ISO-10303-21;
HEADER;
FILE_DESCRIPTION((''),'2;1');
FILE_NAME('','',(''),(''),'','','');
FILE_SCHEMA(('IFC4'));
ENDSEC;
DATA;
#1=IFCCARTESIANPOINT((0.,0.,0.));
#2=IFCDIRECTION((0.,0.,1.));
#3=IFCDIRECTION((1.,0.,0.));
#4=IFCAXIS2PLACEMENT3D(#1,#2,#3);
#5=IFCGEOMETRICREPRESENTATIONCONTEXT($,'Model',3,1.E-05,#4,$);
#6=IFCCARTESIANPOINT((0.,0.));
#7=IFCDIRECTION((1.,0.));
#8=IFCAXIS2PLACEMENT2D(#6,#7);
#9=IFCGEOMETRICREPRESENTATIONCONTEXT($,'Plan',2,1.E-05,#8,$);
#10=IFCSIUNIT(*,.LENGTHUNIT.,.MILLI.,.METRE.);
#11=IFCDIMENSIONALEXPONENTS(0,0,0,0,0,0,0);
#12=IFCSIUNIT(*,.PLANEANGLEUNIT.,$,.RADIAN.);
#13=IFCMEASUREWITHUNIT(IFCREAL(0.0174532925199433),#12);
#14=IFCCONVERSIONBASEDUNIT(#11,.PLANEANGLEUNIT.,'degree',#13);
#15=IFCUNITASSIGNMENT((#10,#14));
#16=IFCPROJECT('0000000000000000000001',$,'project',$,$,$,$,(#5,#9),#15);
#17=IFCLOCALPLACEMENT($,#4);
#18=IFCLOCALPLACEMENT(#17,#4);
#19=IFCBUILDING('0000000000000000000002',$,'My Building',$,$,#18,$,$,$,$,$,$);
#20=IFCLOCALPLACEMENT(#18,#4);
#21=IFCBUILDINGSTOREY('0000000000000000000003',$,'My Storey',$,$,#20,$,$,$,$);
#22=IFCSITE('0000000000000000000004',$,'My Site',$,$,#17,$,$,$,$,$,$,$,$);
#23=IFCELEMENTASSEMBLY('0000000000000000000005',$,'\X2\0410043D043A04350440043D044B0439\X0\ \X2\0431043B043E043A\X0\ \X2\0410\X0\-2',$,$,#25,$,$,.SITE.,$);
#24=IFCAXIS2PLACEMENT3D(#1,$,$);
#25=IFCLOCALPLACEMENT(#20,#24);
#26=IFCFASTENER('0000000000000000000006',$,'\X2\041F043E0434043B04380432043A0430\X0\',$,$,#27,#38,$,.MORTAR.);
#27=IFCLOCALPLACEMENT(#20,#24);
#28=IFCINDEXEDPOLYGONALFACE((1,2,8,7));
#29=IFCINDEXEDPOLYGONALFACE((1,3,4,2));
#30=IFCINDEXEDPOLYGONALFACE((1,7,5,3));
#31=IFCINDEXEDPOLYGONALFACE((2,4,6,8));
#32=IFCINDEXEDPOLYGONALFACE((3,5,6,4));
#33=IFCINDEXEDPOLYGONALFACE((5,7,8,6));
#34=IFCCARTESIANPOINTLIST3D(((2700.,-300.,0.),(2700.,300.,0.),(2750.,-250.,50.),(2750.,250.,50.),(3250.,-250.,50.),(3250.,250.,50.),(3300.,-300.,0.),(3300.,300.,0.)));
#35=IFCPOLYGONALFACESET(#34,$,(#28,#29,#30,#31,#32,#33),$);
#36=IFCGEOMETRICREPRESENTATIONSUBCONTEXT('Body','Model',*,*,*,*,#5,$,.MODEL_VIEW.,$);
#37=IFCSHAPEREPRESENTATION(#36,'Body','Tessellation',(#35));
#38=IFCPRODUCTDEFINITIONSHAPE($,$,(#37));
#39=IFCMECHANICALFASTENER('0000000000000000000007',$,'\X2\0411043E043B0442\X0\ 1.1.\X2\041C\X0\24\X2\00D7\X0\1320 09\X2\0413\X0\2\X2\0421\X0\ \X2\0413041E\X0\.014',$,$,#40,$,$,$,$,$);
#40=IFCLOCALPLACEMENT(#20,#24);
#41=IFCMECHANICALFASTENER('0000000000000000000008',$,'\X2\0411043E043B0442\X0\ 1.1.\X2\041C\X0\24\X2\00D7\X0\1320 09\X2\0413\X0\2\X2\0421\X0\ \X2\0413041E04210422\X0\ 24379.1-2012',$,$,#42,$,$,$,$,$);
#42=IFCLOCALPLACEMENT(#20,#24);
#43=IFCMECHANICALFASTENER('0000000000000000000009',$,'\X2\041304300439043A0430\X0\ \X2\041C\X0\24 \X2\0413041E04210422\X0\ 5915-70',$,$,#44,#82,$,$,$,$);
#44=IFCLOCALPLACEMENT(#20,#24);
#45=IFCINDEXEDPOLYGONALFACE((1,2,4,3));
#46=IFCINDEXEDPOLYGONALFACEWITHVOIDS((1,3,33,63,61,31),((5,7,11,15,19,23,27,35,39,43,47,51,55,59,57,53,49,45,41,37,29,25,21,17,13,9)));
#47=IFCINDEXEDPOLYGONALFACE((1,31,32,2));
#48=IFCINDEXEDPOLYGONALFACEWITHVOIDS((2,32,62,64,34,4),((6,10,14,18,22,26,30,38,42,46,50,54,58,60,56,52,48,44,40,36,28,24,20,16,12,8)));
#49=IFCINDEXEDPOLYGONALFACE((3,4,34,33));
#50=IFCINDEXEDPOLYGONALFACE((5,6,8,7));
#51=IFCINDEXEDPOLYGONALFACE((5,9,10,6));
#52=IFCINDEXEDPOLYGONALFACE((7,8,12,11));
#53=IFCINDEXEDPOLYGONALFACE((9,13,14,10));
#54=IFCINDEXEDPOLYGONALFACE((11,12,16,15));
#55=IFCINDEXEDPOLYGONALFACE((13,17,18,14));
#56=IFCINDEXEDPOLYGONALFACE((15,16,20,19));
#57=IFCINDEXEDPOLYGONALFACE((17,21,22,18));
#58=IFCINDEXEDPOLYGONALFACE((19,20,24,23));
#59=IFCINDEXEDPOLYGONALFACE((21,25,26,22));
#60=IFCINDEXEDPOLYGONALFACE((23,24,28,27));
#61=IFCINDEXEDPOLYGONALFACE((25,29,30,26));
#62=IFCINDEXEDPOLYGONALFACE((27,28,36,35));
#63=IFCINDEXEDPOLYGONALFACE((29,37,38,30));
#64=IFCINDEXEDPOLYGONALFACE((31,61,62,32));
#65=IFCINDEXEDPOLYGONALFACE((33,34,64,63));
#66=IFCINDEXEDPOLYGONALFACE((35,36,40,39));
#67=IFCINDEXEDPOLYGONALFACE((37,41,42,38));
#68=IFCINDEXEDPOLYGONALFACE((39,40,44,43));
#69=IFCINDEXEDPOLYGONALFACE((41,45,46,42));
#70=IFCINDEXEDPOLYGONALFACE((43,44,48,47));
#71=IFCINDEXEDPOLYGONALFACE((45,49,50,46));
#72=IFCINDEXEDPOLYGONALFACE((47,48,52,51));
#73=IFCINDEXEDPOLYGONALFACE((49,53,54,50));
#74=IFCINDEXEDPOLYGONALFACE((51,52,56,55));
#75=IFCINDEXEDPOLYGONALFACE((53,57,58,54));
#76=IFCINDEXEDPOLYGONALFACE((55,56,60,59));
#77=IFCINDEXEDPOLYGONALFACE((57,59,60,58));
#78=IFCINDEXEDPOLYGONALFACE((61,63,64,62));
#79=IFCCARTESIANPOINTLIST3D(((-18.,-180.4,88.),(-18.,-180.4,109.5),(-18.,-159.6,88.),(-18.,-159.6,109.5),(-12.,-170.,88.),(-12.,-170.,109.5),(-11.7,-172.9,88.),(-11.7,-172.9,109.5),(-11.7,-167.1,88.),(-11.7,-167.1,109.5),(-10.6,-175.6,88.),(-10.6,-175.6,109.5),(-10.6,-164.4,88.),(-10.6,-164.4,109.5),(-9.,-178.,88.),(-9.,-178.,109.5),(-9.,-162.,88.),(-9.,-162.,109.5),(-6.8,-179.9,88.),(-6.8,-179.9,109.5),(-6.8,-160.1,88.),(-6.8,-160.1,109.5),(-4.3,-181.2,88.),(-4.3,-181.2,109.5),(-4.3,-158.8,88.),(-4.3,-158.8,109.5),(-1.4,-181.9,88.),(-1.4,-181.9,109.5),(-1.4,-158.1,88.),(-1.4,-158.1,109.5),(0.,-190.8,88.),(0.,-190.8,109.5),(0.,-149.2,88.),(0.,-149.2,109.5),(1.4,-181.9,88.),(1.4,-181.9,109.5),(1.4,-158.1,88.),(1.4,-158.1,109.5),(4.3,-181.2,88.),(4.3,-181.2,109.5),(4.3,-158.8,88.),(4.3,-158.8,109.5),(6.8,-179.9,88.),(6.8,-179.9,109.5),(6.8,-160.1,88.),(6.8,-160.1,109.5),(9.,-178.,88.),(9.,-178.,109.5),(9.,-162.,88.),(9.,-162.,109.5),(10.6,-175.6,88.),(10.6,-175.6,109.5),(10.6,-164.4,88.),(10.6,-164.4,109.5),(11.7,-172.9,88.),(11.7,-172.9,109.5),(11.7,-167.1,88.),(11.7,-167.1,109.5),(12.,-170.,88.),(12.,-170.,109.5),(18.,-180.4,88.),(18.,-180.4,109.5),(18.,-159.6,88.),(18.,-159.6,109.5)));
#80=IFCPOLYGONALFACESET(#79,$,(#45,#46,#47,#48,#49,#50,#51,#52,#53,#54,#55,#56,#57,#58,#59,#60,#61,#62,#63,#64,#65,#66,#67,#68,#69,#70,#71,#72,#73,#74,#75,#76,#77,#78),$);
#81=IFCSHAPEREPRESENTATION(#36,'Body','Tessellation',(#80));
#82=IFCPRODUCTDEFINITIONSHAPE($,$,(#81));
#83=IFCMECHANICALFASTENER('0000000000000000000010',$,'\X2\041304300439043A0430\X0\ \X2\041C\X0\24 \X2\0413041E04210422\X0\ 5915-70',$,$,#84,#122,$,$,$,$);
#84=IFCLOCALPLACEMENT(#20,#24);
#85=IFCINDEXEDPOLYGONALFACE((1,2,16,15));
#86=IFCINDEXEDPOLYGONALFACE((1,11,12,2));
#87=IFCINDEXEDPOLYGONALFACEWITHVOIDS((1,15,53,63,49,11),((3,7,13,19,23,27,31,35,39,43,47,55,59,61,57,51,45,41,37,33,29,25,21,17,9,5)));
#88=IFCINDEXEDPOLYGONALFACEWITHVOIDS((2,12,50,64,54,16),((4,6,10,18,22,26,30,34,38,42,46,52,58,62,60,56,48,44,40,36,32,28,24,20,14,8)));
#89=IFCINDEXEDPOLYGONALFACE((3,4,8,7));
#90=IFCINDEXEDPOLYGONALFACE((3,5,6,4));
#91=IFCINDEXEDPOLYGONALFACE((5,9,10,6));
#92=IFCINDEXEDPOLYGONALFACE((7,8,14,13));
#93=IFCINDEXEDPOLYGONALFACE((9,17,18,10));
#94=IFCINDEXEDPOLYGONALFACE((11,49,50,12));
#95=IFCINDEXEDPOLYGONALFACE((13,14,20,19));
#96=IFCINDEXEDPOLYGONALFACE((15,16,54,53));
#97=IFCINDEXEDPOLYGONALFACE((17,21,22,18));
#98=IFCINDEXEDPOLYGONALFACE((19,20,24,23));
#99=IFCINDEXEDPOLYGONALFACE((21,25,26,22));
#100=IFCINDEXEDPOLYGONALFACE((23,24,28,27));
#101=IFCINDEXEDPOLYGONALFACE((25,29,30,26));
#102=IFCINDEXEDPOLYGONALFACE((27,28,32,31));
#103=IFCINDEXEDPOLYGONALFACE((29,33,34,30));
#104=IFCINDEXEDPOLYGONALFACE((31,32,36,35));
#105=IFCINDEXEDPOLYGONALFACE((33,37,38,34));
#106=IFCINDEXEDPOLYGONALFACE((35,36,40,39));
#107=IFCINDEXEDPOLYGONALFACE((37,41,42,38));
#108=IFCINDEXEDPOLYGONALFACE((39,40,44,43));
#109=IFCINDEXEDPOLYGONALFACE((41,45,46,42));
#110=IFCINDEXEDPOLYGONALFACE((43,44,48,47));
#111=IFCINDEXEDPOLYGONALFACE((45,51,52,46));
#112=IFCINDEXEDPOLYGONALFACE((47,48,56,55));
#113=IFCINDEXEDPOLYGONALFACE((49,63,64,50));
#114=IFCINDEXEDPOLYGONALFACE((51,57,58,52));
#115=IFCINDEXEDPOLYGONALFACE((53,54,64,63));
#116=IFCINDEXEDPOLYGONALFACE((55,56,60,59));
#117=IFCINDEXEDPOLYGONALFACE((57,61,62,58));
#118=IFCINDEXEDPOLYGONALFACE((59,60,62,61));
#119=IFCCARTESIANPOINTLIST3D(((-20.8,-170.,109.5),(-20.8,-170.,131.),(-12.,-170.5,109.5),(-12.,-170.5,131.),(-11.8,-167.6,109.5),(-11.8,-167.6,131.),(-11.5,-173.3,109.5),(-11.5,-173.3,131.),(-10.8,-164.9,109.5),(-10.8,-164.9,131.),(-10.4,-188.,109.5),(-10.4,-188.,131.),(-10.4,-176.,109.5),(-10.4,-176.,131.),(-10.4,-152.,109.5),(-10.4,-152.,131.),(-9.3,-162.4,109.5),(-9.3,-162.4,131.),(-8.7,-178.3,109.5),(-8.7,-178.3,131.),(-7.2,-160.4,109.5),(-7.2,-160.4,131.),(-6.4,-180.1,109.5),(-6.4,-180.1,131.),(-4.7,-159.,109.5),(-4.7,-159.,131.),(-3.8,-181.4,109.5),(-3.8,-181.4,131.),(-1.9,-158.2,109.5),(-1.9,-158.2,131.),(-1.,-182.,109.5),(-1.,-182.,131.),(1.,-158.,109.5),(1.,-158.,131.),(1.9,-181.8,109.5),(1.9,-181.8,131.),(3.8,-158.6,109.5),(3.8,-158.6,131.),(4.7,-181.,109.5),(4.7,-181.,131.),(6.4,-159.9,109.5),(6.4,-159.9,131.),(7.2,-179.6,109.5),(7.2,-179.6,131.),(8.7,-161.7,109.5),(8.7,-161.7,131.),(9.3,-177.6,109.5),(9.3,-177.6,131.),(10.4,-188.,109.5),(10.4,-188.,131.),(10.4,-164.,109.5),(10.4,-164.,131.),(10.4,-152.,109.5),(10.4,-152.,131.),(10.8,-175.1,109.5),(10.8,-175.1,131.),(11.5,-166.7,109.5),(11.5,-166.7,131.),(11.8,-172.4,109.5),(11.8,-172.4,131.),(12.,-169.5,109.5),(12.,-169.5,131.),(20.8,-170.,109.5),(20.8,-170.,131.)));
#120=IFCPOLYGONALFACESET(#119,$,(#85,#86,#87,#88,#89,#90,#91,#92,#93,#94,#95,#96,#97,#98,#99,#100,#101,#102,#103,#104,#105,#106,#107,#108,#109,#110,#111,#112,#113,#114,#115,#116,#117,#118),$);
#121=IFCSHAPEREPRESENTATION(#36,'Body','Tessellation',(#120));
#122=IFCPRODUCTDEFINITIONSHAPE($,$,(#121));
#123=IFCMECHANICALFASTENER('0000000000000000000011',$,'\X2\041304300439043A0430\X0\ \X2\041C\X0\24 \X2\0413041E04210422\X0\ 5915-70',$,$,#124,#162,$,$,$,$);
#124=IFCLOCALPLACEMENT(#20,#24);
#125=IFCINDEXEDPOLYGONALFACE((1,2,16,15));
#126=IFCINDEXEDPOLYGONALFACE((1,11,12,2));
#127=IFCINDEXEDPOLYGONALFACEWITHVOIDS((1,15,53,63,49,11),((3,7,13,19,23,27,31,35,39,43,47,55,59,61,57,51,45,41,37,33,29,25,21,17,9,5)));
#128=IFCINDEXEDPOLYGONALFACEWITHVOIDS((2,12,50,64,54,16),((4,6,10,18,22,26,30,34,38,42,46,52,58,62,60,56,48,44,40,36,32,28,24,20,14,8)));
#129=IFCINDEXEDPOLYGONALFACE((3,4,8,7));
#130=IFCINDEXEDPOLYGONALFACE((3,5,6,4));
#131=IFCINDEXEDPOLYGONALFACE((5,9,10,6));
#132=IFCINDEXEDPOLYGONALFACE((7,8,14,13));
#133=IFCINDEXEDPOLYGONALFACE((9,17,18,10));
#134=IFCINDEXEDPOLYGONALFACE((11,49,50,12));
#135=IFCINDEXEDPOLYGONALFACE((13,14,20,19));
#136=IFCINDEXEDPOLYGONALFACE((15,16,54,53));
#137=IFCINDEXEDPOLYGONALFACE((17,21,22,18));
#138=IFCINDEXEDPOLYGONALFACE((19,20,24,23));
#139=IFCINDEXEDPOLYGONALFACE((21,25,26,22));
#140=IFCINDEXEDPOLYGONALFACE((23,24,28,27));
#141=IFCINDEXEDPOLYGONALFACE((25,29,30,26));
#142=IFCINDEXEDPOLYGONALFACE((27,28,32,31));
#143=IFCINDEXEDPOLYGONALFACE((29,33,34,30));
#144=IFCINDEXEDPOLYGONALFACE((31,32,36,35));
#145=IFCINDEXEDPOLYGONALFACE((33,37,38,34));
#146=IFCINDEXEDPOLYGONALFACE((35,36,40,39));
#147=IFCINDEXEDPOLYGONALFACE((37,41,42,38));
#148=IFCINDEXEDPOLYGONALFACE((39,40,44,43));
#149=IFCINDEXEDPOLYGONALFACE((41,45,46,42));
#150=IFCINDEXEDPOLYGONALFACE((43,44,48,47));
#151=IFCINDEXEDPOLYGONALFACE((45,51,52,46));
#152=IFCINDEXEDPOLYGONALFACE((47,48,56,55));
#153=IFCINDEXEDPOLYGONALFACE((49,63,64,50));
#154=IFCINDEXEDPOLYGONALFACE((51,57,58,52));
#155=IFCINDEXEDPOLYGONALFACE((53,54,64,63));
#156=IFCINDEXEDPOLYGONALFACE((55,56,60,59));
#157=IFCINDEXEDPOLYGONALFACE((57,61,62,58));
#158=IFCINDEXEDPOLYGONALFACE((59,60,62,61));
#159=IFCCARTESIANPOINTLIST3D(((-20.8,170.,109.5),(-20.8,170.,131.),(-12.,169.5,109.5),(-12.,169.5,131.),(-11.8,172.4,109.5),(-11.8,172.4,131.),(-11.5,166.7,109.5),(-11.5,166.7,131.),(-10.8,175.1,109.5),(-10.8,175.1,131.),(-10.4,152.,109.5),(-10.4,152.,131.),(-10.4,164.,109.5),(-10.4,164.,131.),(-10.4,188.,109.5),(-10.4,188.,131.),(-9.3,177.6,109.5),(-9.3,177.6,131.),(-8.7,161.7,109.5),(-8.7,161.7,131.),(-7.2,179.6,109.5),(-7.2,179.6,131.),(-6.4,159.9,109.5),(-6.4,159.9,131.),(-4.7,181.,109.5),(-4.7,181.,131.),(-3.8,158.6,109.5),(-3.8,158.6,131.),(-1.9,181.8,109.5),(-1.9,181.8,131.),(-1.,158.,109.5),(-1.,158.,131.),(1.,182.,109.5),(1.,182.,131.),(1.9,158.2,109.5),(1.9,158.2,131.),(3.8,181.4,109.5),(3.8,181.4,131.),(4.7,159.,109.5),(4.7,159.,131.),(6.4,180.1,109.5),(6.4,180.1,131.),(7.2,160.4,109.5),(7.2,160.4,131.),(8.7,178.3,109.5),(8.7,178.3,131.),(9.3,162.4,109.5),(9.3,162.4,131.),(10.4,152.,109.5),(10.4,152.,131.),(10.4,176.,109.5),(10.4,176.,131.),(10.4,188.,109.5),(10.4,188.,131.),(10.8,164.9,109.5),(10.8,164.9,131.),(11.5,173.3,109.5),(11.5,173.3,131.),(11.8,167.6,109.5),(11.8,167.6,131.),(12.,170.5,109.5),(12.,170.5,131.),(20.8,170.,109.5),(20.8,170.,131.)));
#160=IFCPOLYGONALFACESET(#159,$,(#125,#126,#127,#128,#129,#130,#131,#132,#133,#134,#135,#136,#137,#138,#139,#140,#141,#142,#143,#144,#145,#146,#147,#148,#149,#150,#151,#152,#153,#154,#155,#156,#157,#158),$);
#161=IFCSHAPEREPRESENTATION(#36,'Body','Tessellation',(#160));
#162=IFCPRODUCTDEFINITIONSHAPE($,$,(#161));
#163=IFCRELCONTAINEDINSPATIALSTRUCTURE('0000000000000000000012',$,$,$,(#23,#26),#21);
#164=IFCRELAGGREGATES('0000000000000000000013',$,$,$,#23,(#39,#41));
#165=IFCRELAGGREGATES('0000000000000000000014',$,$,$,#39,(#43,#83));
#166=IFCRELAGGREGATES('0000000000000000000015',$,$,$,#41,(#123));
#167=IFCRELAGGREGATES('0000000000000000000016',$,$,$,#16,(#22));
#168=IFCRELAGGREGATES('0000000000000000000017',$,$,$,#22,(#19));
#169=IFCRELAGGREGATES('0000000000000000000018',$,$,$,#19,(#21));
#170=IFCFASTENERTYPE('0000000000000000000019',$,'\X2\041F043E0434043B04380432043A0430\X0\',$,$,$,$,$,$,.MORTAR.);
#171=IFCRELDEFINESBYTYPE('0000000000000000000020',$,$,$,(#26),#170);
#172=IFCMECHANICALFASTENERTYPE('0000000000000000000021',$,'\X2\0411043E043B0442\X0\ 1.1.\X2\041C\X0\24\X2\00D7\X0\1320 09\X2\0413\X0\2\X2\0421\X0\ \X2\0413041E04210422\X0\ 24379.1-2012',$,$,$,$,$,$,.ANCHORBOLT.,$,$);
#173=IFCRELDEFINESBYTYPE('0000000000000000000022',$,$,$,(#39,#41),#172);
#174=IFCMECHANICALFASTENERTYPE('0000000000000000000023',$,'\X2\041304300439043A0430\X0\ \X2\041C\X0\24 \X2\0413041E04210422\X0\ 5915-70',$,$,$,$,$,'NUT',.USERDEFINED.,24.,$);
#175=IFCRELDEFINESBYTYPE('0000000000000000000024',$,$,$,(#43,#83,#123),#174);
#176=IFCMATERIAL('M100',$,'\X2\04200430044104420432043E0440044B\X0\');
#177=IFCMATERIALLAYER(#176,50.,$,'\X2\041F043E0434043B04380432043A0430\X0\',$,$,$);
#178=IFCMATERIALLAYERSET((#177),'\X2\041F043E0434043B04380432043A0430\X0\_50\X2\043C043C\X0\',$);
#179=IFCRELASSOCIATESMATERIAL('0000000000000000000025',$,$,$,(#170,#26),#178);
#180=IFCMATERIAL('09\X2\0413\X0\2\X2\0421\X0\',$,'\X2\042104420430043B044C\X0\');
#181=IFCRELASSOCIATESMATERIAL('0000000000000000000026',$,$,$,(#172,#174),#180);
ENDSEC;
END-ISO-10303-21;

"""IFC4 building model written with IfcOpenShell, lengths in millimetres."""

from ifc_helpers import new_model, entity, si_unit, converted_unit, frame, origin_with_axes, origin_2d_with_axis, place, context, subcontext, project, spatial, polyline, line, indexed_curve, outline, extrude, clip, halfspace, source, transform, mapped, material, layer, layer_set, layer_usage, type_object, type_shapes, element, aggregate, save


model = new_model("IFC4")

# Units and contexts
model_context = context("Model", 3, precision=1e-05, world=origin_with_axes())
plan_context = context("Plan", 2, precision=1e-05, world=origin_2d_with_axis())
body_context = subcontext(model_context, "Body", "Model", "MODEL_VIEW")
ifc_project = project(units=[si_unit("LENGTHUNIT", "METRE", prefix="MILLI"), converted_unit("PLANEANGLEUNIT", "degree", entity("IfcReal", 0.0174532925199433), si_unit("PLANEANGLEUNIT", "RADIAN"), dimensions=[0, 0, 0, 0, 0, 0, 0])], contexts=[model_context, plan_context])

# Site, building, storey
site_placement = place(None, origin_with_axes())
site = spatial("IfcSite", under=ifc_project, at=site_placement, Name="My Site")
building_placement = place(site_placement, origin_with_axes())
building = spatial("IfcBuilding", under=site, at=building_placement, Name="My Building")
storey_placement = place(building_placement, origin_with_axes())
storey = spatial("IfcBuildingStorey", under=building, at=storey_placement, Name="My Storey")

# Element assembly
placement_1 = place(storey_placement, origin_with_axes())
assembly_1 = element("IfcElementAssembly", 1, at=placement_1, inside=storey, Name="Анкерный блок А-2", AssemblyPlace="SITE")
placement_2 = place(storey_placement, frame((3000.0, 0.0, 0.0), z_axis=(0.0, 0.0, 1.0), x_axis=(1.0, 0.0, 0.0)))

# Fastener
ifc_material_1 = material(Name="M100", Category="Растворы")
ifc_layer_1 = layer(ifc_material_1, 50.0, Name="Подливка")
ifc_layer_set_1 = layer_set([ifc_layer_1], Name="Подливка_50мм")
ifc_layer_usage_1 = layer_usage(ifc_layer_set_1, "AXIS3", "POSITIVE", 0.0)
fastener_type = type_object("IfcFastenerType", Name="Подливка", PredefinedType="MORTAR", material=ifc_layer_set_1)
element("IfcFastener", 2, at=placement_2, inside=storey, type_object=fastener_type, material=ifc_layer_usage_1, Name="Подливка", PredefinedType="MORTAR", context=body_context, shape_type="Clipping", body=[
    clip(clip(clip(clip(extrude(outline(indexed_curve([(-300.0, -300.0), (300.0, -300.0), (300.0, 300.0), (-300.0, 300.0)], segments=[line(3, 2), line(2, 1), line(1, 4), line(4, 3)], self_intersect=False)), None, (0.0, 0.0, 1.0), 50.0), halfspace(frame((-53.6, 200.0, 353.6), z_axis=(0.707107, 0.0, 0.707107), x_axis=(0.707107, 0.0, -0.707107)), False)), halfspace(frame((-200.0, -53.6, 353.6), z_axis=(0.0, 0.707107, 0.707107), x_axis=(0.0, 0.707107, -0.707107)), False)), halfspace(frame((200.0, 53.6, 353.6), z_axis=(0.0, -0.707107, 0.707107), x_axis=(0.0, -0.707107, -0.707107)), False)), halfspace(frame((53.6, 200.0, 353.6), z_axis=(-0.707107, 0.0, 0.707107), x_axis=(-0.707107, 0.0, -0.707107)), False)),
])

# Mechanical fastener
ifc_material_2 = material(Name="09Г2С", Category="Сталь")
mechanical_fastener_type_1 = type_object("IfcMechanicalFastenerType", Name="Болт 1.1.М24×1320 09Г2С ГОСТ 24379.1-2012", PredefinedType="ANCHORBOLT", material=ifc_material_2)
mechanical_fastener_1_placement = place(placement_1, frame((0.0, -170.0, 0.0), z_axis=(0.0, 0.0, 1.0), x_axis=(1.0, 0.0, 0.0)))
mechanical_fastener_1 = element("IfcMechanicalFastener", 3, at=mechanical_fastener_1_placement, type_object=mechanical_fastener_type_1, Name="Болт 1.1.М24×1320 09Г2С ГО.014")

# Mechanical fastener
mechanical_fastener_2_placement = place(placement_1, frame((0.0, 170.0, 0.0), z_axis=(0.0, 0.0, 1.0), x_axis=(-1.0, 0.0, 0.0)))
mechanical_fastener_2 = element("IfcMechanicalFastener", 4, at=mechanical_fastener_2_placement, type_object=mechanical_fastener_type_1, Name="Болт 1.1.М24×1320 09Г2С ГОСТ 24379.1-2012")
aggregate(assembly_1, [mechanical_fastener_1, mechanical_fastener_2])

# Mechanical fasteners
mechanical_fastener_type_2 = type_object("IfcMechanicalFastenerType", Name="Гайка М24 ГОСТ 5915-70", ElementType="NUT", NominalDiameter=24.0, PredefinedType="USERDEFINED", material=ifc_material_2)
shared_shape_1 = source(origin_with_axes(), body_context, "Body", "SweptSolid", [
    extrude(outline(polyline([(-10.4, -18.0), (10.4, -18.0), (20.8, 0.0), (10.4, 18.0), (-10.4, 18.0), (-20.8, 0.0), (-10.4, -18.0)]), holes=[polyline([(-8.0, 9.0), (-5.6, 10.6), (-2.9, 11.7), (0.0, 12.0), (2.9, 11.7), (5.6, 10.6), (8.0, 9.0), (9.9, 6.8), (11.2, 4.3), (11.9, 1.4), (11.9, -1.4), (11.2, -4.3), (9.9, -6.8), (8.0, -9.0), (5.6, -10.6), (2.9, -11.7), (0.0, -12.0), (-2.9, -11.7), (-5.6, -10.6), (-8.0, -9.0), (-9.9, -6.8), (-11.2, -4.3), (-11.9, -1.4), (-11.9, 1.4), (-11.2, 4.3), (-9.9, 6.8), (-8.0, 9.0)])]), frame((0.0, 0.0, 0.0), z_axis=(0.0, 0.0, 1.0), x_axis=(0.0, 1.0, 0.0)), (0.0, 0.0, 1.0), 21.5),
])
type_shapes(mechanical_fastener_type_2, [shared_shape_1])
mechanical_fastener_3_placement = place(mechanical_fastener_1_placement, frame((0.0, 0.0, 88.0), z_axis=(0.0, 0.0, 1.0), x_axis=(1.0, 0.0, 0.0)))
mechanical_fastener_3 = element("IfcMechanicalFastener", 5, at=mechanical_fastener_3_placement, type_object=mechanical_fastener_type_2, Name="Гайка М24 ГОСТ 5915-70", context=body_context, shape_type="MappedRepresentation", body=[
    mapped(shared_shape_1, transform((0.0, 0.0, 0.0), x_axis=(1.0, 0.0, 0.0), y_axis=(0.0, 1.0, 0.0), z_axis=(0.0, 0.0, 1.0), scale=1.0)),
])
mechanical_fastener_4_placement = place(mechanical_fastener_1_placement, frame((0.0, 0.0, 109.5), z_axis=(0.0, 0.0, 1.0), x_axis=(0.866025, 0.5, 0.0)))
mechanical_fastener_4 = element("IfcMechanicalFastener", 6, at=mechanical_fastener_4_placement, type_object=mechanical_fastener_type_2, Name="Гайка М24 ГОСТ 5915-70", context=body_context, shape_type="MappedRepresentation", body=[
    mapped(shared_shape_1, transform((0.0, 0.0, 0.0), x_axis=(1.0, 0.0, 0.0), y_axis=(0.0, 1.0, 0.0), z_axis=(0.0, 0.0, 1.0), scale=1.0)),
])
mechanical_fastener_5_placement = place(mechanical_fastener_2_placement, frame((0.0, 0.0, 109.5), z_axis=(0.0, 0.0, 1.0), x_axis=(0.866025, 0.5, 0.0)))
mechanical_fastener_5 = element("IfcMechanicalFastener", 7, at=mechanical_fastener_5_placement, type_object=mechanical_fastener_type_2, Name="Гайка М24 ГОСТ 5915-70", context=body_context, shape_type="MappedRepresentation", body=[
    mapped(shared_shape_1, transform((0.0, 0.0, 0.0), x_axis=(1.0, 0.0, 0.0), y_axis=(0.0, 1.0, 0.0), z_axis=(0.0, 0.0, 1.0), scale=1.0)),
])
aggregate(mechanical_fastener_1, [mechanical_fastener_3, mechanical_fastener_4])
aggregate(mechanical_fastener_2, [mechanical_fastener_5])

save(model, "model.ifc")
